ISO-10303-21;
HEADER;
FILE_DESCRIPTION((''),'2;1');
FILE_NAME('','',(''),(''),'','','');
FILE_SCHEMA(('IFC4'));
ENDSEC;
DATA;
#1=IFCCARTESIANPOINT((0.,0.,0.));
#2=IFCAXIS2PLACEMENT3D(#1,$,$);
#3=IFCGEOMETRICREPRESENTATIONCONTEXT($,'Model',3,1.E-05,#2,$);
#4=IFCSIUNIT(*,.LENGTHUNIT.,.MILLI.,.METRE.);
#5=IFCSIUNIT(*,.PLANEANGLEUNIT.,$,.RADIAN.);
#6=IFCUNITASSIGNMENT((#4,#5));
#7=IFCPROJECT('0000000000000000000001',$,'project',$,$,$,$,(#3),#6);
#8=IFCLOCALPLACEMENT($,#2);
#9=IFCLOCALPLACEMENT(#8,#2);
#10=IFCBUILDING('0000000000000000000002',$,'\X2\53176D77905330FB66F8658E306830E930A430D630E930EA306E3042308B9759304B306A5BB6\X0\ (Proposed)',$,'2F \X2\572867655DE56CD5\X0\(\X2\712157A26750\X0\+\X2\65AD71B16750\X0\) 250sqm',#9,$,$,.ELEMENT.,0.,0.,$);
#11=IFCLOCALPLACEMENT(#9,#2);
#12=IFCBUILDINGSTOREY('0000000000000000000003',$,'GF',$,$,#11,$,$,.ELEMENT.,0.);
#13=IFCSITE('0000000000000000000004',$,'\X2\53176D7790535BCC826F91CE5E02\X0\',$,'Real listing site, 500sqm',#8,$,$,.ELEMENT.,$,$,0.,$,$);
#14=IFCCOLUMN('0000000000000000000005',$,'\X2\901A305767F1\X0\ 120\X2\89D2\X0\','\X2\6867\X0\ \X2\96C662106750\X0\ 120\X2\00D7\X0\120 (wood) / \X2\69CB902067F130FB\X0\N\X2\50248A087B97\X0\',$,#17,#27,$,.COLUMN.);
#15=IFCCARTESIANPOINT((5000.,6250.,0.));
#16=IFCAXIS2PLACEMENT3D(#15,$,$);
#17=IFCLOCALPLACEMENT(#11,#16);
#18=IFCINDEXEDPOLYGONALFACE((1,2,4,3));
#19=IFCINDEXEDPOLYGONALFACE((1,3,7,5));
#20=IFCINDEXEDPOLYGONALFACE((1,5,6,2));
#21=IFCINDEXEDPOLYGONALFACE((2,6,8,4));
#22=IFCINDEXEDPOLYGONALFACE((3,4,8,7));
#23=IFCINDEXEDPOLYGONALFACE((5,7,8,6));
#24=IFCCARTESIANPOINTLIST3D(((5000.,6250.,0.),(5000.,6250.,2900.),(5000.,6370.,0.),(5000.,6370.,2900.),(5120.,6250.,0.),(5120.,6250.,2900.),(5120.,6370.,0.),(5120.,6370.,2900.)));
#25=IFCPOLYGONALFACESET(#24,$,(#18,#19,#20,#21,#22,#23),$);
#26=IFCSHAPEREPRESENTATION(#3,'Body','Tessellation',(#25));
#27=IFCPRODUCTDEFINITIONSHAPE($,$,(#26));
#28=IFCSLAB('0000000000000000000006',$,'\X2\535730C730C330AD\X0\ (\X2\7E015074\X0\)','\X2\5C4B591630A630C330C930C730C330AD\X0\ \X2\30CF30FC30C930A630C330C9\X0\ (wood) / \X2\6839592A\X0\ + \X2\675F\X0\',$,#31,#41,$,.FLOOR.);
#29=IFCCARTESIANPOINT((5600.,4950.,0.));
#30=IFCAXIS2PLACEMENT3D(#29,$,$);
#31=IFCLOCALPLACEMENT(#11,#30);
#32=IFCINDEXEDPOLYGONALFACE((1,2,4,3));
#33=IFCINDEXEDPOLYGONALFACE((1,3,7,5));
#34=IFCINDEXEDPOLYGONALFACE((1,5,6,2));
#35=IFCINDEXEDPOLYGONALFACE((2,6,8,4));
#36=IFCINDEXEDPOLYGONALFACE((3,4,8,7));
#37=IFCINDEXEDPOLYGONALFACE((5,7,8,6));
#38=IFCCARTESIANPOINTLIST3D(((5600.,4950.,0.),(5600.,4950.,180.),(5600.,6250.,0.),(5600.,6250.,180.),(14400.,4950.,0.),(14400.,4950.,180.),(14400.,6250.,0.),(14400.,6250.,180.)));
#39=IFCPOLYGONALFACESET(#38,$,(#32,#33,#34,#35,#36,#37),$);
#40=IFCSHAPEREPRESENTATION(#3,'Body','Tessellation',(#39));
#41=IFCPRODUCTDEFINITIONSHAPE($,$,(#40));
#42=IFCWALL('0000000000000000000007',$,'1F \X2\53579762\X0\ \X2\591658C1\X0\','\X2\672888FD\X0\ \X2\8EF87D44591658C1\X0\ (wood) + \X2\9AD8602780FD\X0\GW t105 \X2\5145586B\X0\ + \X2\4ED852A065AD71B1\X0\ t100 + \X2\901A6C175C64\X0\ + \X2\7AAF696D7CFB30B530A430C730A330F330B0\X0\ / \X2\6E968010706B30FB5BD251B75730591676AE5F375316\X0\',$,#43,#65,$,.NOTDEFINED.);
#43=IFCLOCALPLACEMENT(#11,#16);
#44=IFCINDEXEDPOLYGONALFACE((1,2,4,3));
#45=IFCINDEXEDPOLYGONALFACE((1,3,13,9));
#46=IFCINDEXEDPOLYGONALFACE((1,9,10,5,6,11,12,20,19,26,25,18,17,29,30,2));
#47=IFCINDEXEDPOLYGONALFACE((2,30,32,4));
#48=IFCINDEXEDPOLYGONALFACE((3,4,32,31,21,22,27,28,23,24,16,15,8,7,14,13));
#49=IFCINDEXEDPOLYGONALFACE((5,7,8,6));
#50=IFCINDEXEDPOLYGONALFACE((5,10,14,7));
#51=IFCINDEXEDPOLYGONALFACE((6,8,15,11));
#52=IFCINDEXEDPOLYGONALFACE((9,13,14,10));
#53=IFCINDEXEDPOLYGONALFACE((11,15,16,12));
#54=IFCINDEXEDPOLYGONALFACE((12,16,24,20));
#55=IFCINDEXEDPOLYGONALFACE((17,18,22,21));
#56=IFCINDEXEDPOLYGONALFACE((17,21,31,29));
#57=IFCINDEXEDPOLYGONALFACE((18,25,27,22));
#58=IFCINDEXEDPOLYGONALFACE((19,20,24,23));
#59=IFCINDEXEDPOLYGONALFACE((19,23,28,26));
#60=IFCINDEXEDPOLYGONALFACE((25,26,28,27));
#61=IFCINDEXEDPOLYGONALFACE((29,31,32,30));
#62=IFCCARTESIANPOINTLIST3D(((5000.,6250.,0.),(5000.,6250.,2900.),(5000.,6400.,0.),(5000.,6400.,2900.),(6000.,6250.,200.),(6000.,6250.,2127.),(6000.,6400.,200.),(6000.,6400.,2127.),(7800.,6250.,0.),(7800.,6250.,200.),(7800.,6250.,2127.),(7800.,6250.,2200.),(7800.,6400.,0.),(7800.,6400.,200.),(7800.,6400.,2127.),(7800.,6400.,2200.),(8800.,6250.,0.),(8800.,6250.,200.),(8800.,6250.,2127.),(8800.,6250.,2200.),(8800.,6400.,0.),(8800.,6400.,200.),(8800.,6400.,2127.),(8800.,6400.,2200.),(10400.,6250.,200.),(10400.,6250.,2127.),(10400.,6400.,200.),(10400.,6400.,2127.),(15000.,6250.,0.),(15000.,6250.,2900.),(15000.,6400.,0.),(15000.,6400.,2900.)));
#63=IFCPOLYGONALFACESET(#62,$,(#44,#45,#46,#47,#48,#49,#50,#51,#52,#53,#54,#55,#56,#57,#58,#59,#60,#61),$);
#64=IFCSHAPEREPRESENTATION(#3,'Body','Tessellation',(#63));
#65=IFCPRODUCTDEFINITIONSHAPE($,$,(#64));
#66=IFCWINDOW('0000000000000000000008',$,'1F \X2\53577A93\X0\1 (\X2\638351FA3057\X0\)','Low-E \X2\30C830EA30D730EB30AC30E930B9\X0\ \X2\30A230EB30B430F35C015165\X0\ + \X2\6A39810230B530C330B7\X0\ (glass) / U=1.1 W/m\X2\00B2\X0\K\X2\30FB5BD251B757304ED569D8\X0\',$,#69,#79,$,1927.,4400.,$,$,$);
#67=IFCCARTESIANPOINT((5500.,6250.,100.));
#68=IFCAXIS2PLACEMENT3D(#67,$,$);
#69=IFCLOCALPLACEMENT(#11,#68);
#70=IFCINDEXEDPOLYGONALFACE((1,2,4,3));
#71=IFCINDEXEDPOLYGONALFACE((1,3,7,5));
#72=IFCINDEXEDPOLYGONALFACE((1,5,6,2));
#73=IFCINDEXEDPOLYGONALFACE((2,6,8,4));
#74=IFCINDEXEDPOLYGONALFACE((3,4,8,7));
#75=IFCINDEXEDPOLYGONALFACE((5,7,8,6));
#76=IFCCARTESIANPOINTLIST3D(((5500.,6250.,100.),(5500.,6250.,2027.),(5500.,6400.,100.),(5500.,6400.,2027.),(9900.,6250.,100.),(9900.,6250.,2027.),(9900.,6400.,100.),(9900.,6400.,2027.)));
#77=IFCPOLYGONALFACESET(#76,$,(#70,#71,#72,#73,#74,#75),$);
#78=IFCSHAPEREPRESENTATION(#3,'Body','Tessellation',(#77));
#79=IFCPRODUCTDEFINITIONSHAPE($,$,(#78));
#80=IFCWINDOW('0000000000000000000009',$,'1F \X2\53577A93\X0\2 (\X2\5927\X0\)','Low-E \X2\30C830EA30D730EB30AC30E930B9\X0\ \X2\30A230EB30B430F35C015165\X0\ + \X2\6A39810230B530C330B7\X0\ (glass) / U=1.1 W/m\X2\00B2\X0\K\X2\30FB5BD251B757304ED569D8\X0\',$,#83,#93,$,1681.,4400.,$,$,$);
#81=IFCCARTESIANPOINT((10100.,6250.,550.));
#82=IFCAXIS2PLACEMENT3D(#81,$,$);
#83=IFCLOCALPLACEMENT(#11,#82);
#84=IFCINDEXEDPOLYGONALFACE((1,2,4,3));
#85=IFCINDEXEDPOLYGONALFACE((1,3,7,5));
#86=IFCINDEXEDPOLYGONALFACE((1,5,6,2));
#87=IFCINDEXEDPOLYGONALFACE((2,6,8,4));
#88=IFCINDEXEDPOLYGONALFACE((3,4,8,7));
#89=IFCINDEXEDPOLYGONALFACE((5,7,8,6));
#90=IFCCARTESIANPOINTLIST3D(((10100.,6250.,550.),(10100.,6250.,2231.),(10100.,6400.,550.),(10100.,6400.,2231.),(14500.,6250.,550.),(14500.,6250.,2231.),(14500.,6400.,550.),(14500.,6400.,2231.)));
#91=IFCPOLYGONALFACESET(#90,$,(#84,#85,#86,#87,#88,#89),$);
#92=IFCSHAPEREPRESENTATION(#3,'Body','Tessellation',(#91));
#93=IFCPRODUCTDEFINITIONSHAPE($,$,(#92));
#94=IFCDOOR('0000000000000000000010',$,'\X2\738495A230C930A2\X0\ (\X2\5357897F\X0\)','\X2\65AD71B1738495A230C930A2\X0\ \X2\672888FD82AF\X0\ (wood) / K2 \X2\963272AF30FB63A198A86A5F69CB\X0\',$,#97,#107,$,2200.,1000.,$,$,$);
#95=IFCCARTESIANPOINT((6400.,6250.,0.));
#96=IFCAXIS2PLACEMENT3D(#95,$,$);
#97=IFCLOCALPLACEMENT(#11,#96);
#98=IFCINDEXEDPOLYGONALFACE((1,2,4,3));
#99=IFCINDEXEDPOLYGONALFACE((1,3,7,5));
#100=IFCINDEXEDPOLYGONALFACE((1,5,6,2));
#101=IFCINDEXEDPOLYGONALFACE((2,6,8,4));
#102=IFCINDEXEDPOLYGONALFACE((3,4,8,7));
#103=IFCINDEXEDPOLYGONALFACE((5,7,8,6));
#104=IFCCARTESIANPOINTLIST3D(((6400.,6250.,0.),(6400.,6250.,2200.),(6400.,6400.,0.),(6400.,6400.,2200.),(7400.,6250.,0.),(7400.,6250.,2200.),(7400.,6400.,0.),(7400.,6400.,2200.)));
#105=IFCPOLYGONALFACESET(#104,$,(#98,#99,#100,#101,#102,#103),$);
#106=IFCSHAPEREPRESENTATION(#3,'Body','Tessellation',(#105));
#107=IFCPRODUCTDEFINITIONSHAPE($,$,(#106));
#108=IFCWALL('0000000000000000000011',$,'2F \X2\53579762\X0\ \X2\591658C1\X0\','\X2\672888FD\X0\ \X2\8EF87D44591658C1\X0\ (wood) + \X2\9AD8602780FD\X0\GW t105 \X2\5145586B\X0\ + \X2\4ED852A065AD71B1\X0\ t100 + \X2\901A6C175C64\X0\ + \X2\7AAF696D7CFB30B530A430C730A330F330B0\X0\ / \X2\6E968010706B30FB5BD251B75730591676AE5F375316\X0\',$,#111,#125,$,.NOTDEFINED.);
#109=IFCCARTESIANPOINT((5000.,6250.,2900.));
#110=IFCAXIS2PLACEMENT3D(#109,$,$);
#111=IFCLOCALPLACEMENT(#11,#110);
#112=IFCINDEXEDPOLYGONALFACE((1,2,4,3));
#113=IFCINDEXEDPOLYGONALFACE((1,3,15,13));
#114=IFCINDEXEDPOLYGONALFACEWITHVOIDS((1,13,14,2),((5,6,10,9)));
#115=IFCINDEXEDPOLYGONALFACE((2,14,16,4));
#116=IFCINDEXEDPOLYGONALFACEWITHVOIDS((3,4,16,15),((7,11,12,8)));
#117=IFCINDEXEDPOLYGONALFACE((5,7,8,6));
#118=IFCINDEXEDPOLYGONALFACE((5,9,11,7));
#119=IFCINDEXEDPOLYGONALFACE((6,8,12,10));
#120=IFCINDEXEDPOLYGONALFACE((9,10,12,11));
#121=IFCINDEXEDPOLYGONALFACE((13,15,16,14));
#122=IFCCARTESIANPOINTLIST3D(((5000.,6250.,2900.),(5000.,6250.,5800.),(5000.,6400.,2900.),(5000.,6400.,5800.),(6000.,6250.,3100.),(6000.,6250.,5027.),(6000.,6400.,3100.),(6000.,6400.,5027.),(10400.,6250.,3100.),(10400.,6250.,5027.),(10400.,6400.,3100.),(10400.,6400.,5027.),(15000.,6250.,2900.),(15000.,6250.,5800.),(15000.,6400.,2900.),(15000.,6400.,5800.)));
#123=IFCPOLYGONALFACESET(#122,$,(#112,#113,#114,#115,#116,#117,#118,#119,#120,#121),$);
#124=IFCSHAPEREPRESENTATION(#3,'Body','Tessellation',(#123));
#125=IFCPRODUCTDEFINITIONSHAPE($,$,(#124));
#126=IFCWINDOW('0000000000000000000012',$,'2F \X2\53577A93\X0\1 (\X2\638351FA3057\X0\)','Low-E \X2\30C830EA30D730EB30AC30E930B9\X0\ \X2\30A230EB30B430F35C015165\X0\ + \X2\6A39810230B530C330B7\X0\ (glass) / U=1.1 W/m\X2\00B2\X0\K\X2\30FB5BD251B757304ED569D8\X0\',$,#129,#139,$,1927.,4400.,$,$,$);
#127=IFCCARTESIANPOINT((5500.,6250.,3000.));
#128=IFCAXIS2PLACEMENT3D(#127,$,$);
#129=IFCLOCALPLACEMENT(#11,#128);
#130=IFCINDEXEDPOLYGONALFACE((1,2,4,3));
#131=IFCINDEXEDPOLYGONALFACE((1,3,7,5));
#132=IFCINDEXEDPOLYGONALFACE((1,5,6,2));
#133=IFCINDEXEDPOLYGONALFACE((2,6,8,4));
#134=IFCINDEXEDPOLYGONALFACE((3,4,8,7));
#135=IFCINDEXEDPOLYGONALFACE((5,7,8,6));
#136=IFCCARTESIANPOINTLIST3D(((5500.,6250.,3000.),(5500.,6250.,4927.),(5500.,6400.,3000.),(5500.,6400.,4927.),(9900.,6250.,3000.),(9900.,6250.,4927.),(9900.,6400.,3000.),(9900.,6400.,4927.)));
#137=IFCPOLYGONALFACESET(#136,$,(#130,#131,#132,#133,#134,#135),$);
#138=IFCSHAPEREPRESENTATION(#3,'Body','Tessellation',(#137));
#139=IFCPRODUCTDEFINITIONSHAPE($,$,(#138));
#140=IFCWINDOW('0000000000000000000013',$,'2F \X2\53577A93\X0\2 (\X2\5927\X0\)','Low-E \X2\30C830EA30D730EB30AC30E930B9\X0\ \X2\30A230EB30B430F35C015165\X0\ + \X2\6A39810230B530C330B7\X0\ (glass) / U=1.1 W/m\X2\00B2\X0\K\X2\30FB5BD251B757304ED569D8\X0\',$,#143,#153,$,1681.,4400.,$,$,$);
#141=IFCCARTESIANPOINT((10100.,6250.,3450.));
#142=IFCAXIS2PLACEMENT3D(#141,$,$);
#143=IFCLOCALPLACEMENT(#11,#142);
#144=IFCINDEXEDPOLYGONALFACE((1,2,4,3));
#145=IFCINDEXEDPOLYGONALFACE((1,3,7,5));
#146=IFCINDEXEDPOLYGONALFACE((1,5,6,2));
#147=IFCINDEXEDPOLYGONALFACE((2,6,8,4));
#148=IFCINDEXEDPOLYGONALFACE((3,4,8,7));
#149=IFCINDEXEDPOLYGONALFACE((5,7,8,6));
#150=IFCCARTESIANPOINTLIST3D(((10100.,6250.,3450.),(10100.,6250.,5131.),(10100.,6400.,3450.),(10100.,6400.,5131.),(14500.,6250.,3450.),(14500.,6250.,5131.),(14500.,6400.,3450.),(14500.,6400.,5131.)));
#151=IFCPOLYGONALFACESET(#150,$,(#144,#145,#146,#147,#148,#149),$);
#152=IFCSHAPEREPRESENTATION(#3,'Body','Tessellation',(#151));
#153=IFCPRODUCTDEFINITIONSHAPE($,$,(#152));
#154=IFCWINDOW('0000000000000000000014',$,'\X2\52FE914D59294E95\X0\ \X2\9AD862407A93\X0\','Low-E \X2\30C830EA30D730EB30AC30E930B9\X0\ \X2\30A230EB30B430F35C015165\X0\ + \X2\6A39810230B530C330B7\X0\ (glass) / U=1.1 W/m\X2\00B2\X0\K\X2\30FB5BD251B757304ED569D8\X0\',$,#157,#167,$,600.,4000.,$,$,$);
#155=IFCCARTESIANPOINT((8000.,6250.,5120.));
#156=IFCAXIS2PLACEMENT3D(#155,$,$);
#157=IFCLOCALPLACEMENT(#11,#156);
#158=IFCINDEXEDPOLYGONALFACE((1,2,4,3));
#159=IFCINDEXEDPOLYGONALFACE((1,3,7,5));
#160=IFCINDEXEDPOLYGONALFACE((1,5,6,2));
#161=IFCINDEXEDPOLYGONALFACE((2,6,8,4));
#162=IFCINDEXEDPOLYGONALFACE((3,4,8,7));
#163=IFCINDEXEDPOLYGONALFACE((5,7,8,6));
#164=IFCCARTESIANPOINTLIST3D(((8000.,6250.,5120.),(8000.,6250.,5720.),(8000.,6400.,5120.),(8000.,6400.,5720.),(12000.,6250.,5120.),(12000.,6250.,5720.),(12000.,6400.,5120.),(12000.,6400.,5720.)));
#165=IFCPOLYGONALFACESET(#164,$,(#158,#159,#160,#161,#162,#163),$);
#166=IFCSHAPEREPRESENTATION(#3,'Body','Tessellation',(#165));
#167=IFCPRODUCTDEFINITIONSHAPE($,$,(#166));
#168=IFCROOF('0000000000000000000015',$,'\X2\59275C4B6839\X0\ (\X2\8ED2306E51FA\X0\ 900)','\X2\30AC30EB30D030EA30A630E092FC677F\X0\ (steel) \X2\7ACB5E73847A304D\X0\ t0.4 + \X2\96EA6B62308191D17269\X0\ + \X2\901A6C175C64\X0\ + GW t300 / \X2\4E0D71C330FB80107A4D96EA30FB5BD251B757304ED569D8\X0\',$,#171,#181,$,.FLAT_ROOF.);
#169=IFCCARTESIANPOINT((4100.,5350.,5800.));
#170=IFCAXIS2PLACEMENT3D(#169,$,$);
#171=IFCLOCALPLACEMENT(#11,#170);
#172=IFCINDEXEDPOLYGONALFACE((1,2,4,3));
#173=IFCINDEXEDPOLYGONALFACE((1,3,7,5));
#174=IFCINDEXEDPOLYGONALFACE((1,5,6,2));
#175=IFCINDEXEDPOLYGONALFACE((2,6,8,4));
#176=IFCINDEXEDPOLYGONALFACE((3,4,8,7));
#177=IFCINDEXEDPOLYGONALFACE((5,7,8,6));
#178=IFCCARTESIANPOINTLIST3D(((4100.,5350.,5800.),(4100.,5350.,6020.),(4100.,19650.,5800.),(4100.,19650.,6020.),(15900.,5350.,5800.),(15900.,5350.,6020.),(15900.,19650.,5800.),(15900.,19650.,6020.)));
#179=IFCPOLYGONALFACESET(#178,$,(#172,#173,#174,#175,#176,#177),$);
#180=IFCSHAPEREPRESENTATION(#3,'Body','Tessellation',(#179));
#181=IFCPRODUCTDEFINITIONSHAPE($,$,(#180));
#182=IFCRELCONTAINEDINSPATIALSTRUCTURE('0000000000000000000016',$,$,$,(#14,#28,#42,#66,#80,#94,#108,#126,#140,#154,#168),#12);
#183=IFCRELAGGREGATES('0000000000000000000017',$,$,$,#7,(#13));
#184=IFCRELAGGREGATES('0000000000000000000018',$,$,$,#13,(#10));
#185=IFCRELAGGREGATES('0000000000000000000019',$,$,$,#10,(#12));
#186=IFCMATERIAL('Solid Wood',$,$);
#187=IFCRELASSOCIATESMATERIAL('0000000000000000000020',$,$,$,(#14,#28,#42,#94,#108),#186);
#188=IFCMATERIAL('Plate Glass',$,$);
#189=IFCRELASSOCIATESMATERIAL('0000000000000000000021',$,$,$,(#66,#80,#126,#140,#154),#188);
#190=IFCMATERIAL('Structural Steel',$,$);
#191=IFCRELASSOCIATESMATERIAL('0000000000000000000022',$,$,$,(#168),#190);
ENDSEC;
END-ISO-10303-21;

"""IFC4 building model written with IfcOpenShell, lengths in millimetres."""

from ifc_helpers import new_model, si_unit, frame, frame_2d, origin, place, context, project, spatial, rectangle, extrude, material, element, fill, save


model = new_model("IFC4")

# Units and contexts
model_context = context("Model", 3, precision=1e-05, world=origin())
ifc_project = project(units=[si_unit("LENGTHUNIT", "METRE", prefix="MILLI"), si_unit("PLANEANGLEUNIT", "RADIAN")], contexts=[model_context])

# Site, building, storey
site_placement = place(None, origin())
site = spatial("IfcSite", under=ifc_project, at=site_placement, Name="北海道富良野市", ObjectType="Real listing site, 500sqm", CompositionType="ELEMENT", RefElevation=0.0)
building_placement = place(site_placement, origin())
building = spatial("IfcBuilding", under=site, at=building_placement, Name="北海道・書斎とライブラリのある静かな家 (Proposed)", ObjectType="2F 在来工法(無垢材+断熱材) 250sqm", CompositionType="ELEMENT", ElevationOfRefHeight=0.0, ElevationOfTerrain=0.0)
storey_placement = place(building_placement, origin())
storey = spatial("IfcBuildingStorey", under=building, at=storey_placement, Name="GF", CompositionType="ELEMENT", Elevation=0.0)

# Column
ifc_material_1 = material(Name="Solid Wood")
column_placement = place(storey_placement, frame((5000.0, 6250.0, 0.0)))
element("IfcColumn", 1, at=column_placement, inside=storey, material=ifc_material_1, Name="通し柱 120角", Description="桧 集成材 120×120 (wood) / 構造柱・N値計算", PredefinedType="COLUMN", context=model_context, shape_type="SweptSolid", body=[
    extrude(rectangle(XDim=120.0, YDim=120.0, at=frame_2d((60.0, 60.0))), frame((5000.0, 6250.0, 0.0)), (0.0, 0.0, 1.0), 2900.0),
])

# Slab
slab_1_placement = place(storey_placement, frame((5600.0, 4950.0, 0.0)))
element("IfcSlab", 2, at=slab_1_placement, inside=storey, material=ifc_material_1, Name="南デッキ (縁側)", Description="屋外ウッドデッキ ハードウッド (wood) / 根太 + 束", PredefinedType="FLOOR", context=model_context, shape_type="SweptSolid", body=[
    extrude(rectangle(XDim=8800.0, YDim=1300.0, at=frame_2d((4400.0, 650.0))), frame((5600.0, 4950.0, 0.0)), (0.0, 0.0, 1.0), 180.0),
])

# Wall, openings, windows, door
wall_1_placement = place(storey_placement, frame((5000.0, 6250.0, 0.0)))
wall_1 = element("IfcWall", 3, at=wall_1_placement, inside=storey, material=ifc_material_1, Name="1F 南面 外壁", Description="木製 軸組外壁 (wood) + 高性能GW t105 充填 + 付加断熱 t100 + 通気層 + 窯業系サイディング / 準耐火・寒冷地外皮強化", PredefinedType="NOTDEFINED", context=model_context, shape_type="SweptSolid", body=[
    extrude(rectangle(XDim=10000.0, YDim=150.0, at=frame_2d((5000.0, 75.0))), frame((5000.0, 6250.0, 0.0)), (0.0, 0.0, 1.0), 2900.0),
])
opening_1_placement = place(storey_placement, frame((5500.0, 6250.0, 100.0)))
opening_1 = element("IfcOpeningElement", 4, at=opening_1_placement, cuts=wall_1, PredefinedType="NOTDEFINED", context=model_context, shape_type="SweptSolid", body=[
    extrude(rectangle(XDim=4400.0, YDim=150.0, at=frame_2d((2200.0, 75.0))), frame((5500.0, 6250.0, 100.0)), (0.0, 0.0, 1.0), 1927.0),
])
opening_2_placement = place(storey_placement, frame((10100.0, 6250.0, 550.0)))
opening_2 = element("IfcOpeningElement", 5, at=opening_2_placement, cuts=wall_1, PredefinedType="NOTDEFINED", context=model_context, shape_type="SweptSolid", body=[
    extrude(rectangle(XDim=4400.0, YDim=150.0, at=frame_2d((2200.0, 75.0))), frame((10100.0, 6250.0, 550.0)), (0.0, 0.0, 1.0), 1681.0),
])
opening_3_placement = place(storey_placement, frame((6400.0, 6250.0, 0.0)))
opening_3 = element("IfcOpeningElement", 6, at=opening_3_placement, cuts=wall_1, PredefinedType="NOTDEFINED", context=model_context, shape_type="SweptSolid", body=[
    extrude(rectangle(XDim=1000.0, YDim=150.0, at=frame_2d((500.0, 75.0))), frame((6400.0, 6250.0, 0.0)), (0.0, 0.0, 1.0), 2200.0),
])
ifc_material_2 = material(Name="Plate Glass")
window_1_placement = place(storey_placement, frame((5500.0, 6250.0, 100.0)))
window_1 = element("IfcWindow", 7, at=window_1_placement, inside=storey, material=ifc_material_2, Name="1F 南窓1 (掃出し)", Description="Low-E トリプルガラス アルゴン封入 + 樹脂サッシ (glass) / U=1.1 W/m²K・寒冷地仕様", OverallHeight=1927.0, OverallWidth=4400.0, context=model_context, shape_type="SweptSolid", body=[
    extrude(rectangle(XDim=4400.0, YDim=150.0, at=frame_2d((2200.0, 75.0))), frame((5500.0, 6250.0, 100.0)), (0.0, 0.0, 1.0), 1927.0),
])
fill(opening_1, window_1)
window_2_placement = place(storey_placement, frame((10100.0, 6250.0, 550.0)))
window_2 = element("IfcWindow", 8, at=window_2_placement, inside=storey, material=ifc_material_2, Name="1F 南窓2 (大)", Description="Low-E トリプルガラス アルゴン封入 + 樹脂サッシ (glass) / U=1.1 W/m²K・寒冷地仕様", OverallHeight=1681.0, OverallWidth=4400.0, context=model_context, shape_type="SweptSolid", body=[
    extrude(rectangle(XDim=4400.0, YDim=150.0, at=frame_2d((2200.0, 75.0))), frame((10100.0, 6250.0, 550.0)), (0.0, 0.0, 1.0), 1681.0),
])
fill(opening_2, window_2)
door_placement = place(storey_placement, frame((6400.0, 6250.0, 0.0)))
door = element("IfcDoor", 9, at=door_placement, inside=storey, material=ifc_material_1, Name="玄関ドア (南西)", Description="断熱玄関ドア 木製芯 (wood) / K2 防犯・採風機構", OverallHeight=2200.0, OverallWidth=1000.0, context=model_context, shape_type="SweptSolid", body=[
    extrude(rectangle(XDim=1000.0, YDim=150.0, at=frame_2d((500.0, 75.0))), frame((6400.0, 6250.0, 0.0)), (0.0, 0.0, 1.0), 2200.0),
])
fill(opening_3, door)

# Wall, openings, windows
wall_2_placement = place(storey_placement, frame((5000.0, 6250.0, 2900.0)))
wall_2 = element("IfcWall", 10, at=wall_2_placement, inside=storey, material=ifc_material_1, Name="2F 南面 外壁", Description="木製 軸組外壁 (wood) + 高性能GW t105 充填 + 付加断熱 t100 + 通気層 + 窯業系サイディング / 準耐火・寒冷地外皮強化", PredefinedType="NOTDEFINED", context=model_context, shape_type="SweptSolid", body=[
    extrude(rectangle(XDim=10000.0, YDim=150.0, at=frame_2d((5000.0, 75.0))), frame((5000.0, 6250.0, 2900.0)), (0.0, 0.0, 1.0), 2900.0),
])
opening_4_placement = place(storey_placement, frame((5500.0, 6250.0, 3000.0)))
opening_4 = element("IfcOpeningElement", 11, at=opening_4_placement, cuts=wall_2, PredefinedType="NOTDEFINED", context=model_context, shape_type="SweptSolid", body=[
    extrude(rectangle(XDim=4400.0, YDim=150.0, at=frame_2d((2200.0, 75.0))), frame((5500.0, 6250.0, 3000.0)), (0.0, 0.0, 1.0), 1927.0),
])
opening_5_placement = place(storey_placement, frame((10100.0, 6250.0, 3450.0)))
opening_5 = element("IfcOpeningElement", 12, at=opening_5_placement, cuts=wall_2, PredefinedType="NOTDEFINED", context=model_context, shape_type="SweptSolid", body=[
    extrude(rectangle(XDim=4400.0, YDim=150.0, at=frame_2d((2200.0, 75.0))), frame((10100.0, 6250.0, 3450.0)), (0.0, 0.0, 1.0), 1681.0),
])
opening_6_placement = place(storey_placement, frame((8000.0, 6250.0, 5120.0)))
opening_6 = element("IfcOpeningElement", 13, at=opening_6_placement, cuts=wall_2, PredefinedType="NOTDEFINED", context=model_context, shape_type="SweptSolid", body=[
    extrude(rectangle(XDim=4000.0, YDim=150.0, at=frame_2d((2000.0, 75.0))), frame((8000.0, 6250.0, 5120.0)), (0.0, 0.0, 1.0), 600.0),
])
window_3_placement = place(storey_placement, frame((5500.0, 6250.0, 3000.0)))
window_3 = element("IfcWindow", 14, at=window_3_placement, inside=storey, material=ifc_material_2, Name="2F 南窓1 (掃出し)", Description="Low-E トリプルガラス アルゴン封入 + 樹脂サッシ (glass) / U=1.1 W/m²K・寒冷地仕様", OverallHeight=1927.0, OverallWidth=4400.0, context=model_context, shape_type="SweptSolid", body=[
    extrude(rectangle(XDim=4400.0, YDim=150.0, at=frame_2d((2200.0, 75.0))), frame((5500.0, 6250.0, 3000.0)), (0.0, 0.0, 1.0), 1927.0),
])
fill(opening_4, window_3)
window_4_placement = place(storey_placement, frame((10100.0, 6250.0, 3450.0)))
window_4 = element("IfcWindow", 15, at=window_4_placement, inside=storey, material=ifc_material_2, Name="2F 南窓2 (大)", Description="Low-E トリプルガラス アルゴン封入 + 樹脂サッシ (glass) / U=1.1 W/m²K・寒冷地仕様", OverallHeight=1681.0, OverallWidth=4400.0, context=model_context, shape_type="SweptSolid", body=[
    extrude(rectangle(XDim=4400.0, YDim=150.0, at=frame_2d((2200.0, 75.0))), frame((10100.0, 6250.0, 3450.0)), (0.0, 0.0, 1.0), 1681.0),
])
fill(opening_5, window_4)
window_5_placement = place(storey_placement, frame((8000.0, 6250.0, 5120.0)))
window_5 = element("IfcWindow", 16, at=window_5_placement, inside=storey, material=ifc_material_2, Name="勾配天井 高所窓", Description="Low-E トリプルガラス アルゴン封入 + 樹脂サッシ (glass) / U=1.1 W/m²K・寒冷地仕様", OverallHeight=600.0, OverallWidth=4000.0, context=model_context, shape_type="SweptSolid", body=[
    extrude(rectangle(XDim=4000.0, YDim=150.0, at=frame_2d((2000.0, 75.0))), frame((8000.0, 6250.0, 5120.0)), (0.0, 0.0, 1.0), 600.0),
])
fill(opening_6, window_5)

# Roof
ifc_material_3 = material(Name="Structural Steel")
roof_placement = place(storey_placement, frame((4100.0, 5350.0, 5800.0)))
element("IfcRoof", 17, at=roof_placement, inside=storey, material=ifc_material_3, Name="大屋根 (軒の出 900)", Description="ガルバリウム鋼板 (steel) 立平葺き t0.4 + 雪止め金物 + 通気層 + GW t300 / 不燃・耐積雪・寒冷地仕様", PredefinedType="FLAT_ROOF", context=model_context, shape_type="SweptSolid", body=[
    extrude(rectangle(XDim=11800.0, YDim=14300.0, at=frame_2d((5900.0, 7150.0))), frame((4100.0, 5350.0, 5800.0)), (0.0, 0.0, 1.0), 220.0),
])

save(model, "model.ifc")
